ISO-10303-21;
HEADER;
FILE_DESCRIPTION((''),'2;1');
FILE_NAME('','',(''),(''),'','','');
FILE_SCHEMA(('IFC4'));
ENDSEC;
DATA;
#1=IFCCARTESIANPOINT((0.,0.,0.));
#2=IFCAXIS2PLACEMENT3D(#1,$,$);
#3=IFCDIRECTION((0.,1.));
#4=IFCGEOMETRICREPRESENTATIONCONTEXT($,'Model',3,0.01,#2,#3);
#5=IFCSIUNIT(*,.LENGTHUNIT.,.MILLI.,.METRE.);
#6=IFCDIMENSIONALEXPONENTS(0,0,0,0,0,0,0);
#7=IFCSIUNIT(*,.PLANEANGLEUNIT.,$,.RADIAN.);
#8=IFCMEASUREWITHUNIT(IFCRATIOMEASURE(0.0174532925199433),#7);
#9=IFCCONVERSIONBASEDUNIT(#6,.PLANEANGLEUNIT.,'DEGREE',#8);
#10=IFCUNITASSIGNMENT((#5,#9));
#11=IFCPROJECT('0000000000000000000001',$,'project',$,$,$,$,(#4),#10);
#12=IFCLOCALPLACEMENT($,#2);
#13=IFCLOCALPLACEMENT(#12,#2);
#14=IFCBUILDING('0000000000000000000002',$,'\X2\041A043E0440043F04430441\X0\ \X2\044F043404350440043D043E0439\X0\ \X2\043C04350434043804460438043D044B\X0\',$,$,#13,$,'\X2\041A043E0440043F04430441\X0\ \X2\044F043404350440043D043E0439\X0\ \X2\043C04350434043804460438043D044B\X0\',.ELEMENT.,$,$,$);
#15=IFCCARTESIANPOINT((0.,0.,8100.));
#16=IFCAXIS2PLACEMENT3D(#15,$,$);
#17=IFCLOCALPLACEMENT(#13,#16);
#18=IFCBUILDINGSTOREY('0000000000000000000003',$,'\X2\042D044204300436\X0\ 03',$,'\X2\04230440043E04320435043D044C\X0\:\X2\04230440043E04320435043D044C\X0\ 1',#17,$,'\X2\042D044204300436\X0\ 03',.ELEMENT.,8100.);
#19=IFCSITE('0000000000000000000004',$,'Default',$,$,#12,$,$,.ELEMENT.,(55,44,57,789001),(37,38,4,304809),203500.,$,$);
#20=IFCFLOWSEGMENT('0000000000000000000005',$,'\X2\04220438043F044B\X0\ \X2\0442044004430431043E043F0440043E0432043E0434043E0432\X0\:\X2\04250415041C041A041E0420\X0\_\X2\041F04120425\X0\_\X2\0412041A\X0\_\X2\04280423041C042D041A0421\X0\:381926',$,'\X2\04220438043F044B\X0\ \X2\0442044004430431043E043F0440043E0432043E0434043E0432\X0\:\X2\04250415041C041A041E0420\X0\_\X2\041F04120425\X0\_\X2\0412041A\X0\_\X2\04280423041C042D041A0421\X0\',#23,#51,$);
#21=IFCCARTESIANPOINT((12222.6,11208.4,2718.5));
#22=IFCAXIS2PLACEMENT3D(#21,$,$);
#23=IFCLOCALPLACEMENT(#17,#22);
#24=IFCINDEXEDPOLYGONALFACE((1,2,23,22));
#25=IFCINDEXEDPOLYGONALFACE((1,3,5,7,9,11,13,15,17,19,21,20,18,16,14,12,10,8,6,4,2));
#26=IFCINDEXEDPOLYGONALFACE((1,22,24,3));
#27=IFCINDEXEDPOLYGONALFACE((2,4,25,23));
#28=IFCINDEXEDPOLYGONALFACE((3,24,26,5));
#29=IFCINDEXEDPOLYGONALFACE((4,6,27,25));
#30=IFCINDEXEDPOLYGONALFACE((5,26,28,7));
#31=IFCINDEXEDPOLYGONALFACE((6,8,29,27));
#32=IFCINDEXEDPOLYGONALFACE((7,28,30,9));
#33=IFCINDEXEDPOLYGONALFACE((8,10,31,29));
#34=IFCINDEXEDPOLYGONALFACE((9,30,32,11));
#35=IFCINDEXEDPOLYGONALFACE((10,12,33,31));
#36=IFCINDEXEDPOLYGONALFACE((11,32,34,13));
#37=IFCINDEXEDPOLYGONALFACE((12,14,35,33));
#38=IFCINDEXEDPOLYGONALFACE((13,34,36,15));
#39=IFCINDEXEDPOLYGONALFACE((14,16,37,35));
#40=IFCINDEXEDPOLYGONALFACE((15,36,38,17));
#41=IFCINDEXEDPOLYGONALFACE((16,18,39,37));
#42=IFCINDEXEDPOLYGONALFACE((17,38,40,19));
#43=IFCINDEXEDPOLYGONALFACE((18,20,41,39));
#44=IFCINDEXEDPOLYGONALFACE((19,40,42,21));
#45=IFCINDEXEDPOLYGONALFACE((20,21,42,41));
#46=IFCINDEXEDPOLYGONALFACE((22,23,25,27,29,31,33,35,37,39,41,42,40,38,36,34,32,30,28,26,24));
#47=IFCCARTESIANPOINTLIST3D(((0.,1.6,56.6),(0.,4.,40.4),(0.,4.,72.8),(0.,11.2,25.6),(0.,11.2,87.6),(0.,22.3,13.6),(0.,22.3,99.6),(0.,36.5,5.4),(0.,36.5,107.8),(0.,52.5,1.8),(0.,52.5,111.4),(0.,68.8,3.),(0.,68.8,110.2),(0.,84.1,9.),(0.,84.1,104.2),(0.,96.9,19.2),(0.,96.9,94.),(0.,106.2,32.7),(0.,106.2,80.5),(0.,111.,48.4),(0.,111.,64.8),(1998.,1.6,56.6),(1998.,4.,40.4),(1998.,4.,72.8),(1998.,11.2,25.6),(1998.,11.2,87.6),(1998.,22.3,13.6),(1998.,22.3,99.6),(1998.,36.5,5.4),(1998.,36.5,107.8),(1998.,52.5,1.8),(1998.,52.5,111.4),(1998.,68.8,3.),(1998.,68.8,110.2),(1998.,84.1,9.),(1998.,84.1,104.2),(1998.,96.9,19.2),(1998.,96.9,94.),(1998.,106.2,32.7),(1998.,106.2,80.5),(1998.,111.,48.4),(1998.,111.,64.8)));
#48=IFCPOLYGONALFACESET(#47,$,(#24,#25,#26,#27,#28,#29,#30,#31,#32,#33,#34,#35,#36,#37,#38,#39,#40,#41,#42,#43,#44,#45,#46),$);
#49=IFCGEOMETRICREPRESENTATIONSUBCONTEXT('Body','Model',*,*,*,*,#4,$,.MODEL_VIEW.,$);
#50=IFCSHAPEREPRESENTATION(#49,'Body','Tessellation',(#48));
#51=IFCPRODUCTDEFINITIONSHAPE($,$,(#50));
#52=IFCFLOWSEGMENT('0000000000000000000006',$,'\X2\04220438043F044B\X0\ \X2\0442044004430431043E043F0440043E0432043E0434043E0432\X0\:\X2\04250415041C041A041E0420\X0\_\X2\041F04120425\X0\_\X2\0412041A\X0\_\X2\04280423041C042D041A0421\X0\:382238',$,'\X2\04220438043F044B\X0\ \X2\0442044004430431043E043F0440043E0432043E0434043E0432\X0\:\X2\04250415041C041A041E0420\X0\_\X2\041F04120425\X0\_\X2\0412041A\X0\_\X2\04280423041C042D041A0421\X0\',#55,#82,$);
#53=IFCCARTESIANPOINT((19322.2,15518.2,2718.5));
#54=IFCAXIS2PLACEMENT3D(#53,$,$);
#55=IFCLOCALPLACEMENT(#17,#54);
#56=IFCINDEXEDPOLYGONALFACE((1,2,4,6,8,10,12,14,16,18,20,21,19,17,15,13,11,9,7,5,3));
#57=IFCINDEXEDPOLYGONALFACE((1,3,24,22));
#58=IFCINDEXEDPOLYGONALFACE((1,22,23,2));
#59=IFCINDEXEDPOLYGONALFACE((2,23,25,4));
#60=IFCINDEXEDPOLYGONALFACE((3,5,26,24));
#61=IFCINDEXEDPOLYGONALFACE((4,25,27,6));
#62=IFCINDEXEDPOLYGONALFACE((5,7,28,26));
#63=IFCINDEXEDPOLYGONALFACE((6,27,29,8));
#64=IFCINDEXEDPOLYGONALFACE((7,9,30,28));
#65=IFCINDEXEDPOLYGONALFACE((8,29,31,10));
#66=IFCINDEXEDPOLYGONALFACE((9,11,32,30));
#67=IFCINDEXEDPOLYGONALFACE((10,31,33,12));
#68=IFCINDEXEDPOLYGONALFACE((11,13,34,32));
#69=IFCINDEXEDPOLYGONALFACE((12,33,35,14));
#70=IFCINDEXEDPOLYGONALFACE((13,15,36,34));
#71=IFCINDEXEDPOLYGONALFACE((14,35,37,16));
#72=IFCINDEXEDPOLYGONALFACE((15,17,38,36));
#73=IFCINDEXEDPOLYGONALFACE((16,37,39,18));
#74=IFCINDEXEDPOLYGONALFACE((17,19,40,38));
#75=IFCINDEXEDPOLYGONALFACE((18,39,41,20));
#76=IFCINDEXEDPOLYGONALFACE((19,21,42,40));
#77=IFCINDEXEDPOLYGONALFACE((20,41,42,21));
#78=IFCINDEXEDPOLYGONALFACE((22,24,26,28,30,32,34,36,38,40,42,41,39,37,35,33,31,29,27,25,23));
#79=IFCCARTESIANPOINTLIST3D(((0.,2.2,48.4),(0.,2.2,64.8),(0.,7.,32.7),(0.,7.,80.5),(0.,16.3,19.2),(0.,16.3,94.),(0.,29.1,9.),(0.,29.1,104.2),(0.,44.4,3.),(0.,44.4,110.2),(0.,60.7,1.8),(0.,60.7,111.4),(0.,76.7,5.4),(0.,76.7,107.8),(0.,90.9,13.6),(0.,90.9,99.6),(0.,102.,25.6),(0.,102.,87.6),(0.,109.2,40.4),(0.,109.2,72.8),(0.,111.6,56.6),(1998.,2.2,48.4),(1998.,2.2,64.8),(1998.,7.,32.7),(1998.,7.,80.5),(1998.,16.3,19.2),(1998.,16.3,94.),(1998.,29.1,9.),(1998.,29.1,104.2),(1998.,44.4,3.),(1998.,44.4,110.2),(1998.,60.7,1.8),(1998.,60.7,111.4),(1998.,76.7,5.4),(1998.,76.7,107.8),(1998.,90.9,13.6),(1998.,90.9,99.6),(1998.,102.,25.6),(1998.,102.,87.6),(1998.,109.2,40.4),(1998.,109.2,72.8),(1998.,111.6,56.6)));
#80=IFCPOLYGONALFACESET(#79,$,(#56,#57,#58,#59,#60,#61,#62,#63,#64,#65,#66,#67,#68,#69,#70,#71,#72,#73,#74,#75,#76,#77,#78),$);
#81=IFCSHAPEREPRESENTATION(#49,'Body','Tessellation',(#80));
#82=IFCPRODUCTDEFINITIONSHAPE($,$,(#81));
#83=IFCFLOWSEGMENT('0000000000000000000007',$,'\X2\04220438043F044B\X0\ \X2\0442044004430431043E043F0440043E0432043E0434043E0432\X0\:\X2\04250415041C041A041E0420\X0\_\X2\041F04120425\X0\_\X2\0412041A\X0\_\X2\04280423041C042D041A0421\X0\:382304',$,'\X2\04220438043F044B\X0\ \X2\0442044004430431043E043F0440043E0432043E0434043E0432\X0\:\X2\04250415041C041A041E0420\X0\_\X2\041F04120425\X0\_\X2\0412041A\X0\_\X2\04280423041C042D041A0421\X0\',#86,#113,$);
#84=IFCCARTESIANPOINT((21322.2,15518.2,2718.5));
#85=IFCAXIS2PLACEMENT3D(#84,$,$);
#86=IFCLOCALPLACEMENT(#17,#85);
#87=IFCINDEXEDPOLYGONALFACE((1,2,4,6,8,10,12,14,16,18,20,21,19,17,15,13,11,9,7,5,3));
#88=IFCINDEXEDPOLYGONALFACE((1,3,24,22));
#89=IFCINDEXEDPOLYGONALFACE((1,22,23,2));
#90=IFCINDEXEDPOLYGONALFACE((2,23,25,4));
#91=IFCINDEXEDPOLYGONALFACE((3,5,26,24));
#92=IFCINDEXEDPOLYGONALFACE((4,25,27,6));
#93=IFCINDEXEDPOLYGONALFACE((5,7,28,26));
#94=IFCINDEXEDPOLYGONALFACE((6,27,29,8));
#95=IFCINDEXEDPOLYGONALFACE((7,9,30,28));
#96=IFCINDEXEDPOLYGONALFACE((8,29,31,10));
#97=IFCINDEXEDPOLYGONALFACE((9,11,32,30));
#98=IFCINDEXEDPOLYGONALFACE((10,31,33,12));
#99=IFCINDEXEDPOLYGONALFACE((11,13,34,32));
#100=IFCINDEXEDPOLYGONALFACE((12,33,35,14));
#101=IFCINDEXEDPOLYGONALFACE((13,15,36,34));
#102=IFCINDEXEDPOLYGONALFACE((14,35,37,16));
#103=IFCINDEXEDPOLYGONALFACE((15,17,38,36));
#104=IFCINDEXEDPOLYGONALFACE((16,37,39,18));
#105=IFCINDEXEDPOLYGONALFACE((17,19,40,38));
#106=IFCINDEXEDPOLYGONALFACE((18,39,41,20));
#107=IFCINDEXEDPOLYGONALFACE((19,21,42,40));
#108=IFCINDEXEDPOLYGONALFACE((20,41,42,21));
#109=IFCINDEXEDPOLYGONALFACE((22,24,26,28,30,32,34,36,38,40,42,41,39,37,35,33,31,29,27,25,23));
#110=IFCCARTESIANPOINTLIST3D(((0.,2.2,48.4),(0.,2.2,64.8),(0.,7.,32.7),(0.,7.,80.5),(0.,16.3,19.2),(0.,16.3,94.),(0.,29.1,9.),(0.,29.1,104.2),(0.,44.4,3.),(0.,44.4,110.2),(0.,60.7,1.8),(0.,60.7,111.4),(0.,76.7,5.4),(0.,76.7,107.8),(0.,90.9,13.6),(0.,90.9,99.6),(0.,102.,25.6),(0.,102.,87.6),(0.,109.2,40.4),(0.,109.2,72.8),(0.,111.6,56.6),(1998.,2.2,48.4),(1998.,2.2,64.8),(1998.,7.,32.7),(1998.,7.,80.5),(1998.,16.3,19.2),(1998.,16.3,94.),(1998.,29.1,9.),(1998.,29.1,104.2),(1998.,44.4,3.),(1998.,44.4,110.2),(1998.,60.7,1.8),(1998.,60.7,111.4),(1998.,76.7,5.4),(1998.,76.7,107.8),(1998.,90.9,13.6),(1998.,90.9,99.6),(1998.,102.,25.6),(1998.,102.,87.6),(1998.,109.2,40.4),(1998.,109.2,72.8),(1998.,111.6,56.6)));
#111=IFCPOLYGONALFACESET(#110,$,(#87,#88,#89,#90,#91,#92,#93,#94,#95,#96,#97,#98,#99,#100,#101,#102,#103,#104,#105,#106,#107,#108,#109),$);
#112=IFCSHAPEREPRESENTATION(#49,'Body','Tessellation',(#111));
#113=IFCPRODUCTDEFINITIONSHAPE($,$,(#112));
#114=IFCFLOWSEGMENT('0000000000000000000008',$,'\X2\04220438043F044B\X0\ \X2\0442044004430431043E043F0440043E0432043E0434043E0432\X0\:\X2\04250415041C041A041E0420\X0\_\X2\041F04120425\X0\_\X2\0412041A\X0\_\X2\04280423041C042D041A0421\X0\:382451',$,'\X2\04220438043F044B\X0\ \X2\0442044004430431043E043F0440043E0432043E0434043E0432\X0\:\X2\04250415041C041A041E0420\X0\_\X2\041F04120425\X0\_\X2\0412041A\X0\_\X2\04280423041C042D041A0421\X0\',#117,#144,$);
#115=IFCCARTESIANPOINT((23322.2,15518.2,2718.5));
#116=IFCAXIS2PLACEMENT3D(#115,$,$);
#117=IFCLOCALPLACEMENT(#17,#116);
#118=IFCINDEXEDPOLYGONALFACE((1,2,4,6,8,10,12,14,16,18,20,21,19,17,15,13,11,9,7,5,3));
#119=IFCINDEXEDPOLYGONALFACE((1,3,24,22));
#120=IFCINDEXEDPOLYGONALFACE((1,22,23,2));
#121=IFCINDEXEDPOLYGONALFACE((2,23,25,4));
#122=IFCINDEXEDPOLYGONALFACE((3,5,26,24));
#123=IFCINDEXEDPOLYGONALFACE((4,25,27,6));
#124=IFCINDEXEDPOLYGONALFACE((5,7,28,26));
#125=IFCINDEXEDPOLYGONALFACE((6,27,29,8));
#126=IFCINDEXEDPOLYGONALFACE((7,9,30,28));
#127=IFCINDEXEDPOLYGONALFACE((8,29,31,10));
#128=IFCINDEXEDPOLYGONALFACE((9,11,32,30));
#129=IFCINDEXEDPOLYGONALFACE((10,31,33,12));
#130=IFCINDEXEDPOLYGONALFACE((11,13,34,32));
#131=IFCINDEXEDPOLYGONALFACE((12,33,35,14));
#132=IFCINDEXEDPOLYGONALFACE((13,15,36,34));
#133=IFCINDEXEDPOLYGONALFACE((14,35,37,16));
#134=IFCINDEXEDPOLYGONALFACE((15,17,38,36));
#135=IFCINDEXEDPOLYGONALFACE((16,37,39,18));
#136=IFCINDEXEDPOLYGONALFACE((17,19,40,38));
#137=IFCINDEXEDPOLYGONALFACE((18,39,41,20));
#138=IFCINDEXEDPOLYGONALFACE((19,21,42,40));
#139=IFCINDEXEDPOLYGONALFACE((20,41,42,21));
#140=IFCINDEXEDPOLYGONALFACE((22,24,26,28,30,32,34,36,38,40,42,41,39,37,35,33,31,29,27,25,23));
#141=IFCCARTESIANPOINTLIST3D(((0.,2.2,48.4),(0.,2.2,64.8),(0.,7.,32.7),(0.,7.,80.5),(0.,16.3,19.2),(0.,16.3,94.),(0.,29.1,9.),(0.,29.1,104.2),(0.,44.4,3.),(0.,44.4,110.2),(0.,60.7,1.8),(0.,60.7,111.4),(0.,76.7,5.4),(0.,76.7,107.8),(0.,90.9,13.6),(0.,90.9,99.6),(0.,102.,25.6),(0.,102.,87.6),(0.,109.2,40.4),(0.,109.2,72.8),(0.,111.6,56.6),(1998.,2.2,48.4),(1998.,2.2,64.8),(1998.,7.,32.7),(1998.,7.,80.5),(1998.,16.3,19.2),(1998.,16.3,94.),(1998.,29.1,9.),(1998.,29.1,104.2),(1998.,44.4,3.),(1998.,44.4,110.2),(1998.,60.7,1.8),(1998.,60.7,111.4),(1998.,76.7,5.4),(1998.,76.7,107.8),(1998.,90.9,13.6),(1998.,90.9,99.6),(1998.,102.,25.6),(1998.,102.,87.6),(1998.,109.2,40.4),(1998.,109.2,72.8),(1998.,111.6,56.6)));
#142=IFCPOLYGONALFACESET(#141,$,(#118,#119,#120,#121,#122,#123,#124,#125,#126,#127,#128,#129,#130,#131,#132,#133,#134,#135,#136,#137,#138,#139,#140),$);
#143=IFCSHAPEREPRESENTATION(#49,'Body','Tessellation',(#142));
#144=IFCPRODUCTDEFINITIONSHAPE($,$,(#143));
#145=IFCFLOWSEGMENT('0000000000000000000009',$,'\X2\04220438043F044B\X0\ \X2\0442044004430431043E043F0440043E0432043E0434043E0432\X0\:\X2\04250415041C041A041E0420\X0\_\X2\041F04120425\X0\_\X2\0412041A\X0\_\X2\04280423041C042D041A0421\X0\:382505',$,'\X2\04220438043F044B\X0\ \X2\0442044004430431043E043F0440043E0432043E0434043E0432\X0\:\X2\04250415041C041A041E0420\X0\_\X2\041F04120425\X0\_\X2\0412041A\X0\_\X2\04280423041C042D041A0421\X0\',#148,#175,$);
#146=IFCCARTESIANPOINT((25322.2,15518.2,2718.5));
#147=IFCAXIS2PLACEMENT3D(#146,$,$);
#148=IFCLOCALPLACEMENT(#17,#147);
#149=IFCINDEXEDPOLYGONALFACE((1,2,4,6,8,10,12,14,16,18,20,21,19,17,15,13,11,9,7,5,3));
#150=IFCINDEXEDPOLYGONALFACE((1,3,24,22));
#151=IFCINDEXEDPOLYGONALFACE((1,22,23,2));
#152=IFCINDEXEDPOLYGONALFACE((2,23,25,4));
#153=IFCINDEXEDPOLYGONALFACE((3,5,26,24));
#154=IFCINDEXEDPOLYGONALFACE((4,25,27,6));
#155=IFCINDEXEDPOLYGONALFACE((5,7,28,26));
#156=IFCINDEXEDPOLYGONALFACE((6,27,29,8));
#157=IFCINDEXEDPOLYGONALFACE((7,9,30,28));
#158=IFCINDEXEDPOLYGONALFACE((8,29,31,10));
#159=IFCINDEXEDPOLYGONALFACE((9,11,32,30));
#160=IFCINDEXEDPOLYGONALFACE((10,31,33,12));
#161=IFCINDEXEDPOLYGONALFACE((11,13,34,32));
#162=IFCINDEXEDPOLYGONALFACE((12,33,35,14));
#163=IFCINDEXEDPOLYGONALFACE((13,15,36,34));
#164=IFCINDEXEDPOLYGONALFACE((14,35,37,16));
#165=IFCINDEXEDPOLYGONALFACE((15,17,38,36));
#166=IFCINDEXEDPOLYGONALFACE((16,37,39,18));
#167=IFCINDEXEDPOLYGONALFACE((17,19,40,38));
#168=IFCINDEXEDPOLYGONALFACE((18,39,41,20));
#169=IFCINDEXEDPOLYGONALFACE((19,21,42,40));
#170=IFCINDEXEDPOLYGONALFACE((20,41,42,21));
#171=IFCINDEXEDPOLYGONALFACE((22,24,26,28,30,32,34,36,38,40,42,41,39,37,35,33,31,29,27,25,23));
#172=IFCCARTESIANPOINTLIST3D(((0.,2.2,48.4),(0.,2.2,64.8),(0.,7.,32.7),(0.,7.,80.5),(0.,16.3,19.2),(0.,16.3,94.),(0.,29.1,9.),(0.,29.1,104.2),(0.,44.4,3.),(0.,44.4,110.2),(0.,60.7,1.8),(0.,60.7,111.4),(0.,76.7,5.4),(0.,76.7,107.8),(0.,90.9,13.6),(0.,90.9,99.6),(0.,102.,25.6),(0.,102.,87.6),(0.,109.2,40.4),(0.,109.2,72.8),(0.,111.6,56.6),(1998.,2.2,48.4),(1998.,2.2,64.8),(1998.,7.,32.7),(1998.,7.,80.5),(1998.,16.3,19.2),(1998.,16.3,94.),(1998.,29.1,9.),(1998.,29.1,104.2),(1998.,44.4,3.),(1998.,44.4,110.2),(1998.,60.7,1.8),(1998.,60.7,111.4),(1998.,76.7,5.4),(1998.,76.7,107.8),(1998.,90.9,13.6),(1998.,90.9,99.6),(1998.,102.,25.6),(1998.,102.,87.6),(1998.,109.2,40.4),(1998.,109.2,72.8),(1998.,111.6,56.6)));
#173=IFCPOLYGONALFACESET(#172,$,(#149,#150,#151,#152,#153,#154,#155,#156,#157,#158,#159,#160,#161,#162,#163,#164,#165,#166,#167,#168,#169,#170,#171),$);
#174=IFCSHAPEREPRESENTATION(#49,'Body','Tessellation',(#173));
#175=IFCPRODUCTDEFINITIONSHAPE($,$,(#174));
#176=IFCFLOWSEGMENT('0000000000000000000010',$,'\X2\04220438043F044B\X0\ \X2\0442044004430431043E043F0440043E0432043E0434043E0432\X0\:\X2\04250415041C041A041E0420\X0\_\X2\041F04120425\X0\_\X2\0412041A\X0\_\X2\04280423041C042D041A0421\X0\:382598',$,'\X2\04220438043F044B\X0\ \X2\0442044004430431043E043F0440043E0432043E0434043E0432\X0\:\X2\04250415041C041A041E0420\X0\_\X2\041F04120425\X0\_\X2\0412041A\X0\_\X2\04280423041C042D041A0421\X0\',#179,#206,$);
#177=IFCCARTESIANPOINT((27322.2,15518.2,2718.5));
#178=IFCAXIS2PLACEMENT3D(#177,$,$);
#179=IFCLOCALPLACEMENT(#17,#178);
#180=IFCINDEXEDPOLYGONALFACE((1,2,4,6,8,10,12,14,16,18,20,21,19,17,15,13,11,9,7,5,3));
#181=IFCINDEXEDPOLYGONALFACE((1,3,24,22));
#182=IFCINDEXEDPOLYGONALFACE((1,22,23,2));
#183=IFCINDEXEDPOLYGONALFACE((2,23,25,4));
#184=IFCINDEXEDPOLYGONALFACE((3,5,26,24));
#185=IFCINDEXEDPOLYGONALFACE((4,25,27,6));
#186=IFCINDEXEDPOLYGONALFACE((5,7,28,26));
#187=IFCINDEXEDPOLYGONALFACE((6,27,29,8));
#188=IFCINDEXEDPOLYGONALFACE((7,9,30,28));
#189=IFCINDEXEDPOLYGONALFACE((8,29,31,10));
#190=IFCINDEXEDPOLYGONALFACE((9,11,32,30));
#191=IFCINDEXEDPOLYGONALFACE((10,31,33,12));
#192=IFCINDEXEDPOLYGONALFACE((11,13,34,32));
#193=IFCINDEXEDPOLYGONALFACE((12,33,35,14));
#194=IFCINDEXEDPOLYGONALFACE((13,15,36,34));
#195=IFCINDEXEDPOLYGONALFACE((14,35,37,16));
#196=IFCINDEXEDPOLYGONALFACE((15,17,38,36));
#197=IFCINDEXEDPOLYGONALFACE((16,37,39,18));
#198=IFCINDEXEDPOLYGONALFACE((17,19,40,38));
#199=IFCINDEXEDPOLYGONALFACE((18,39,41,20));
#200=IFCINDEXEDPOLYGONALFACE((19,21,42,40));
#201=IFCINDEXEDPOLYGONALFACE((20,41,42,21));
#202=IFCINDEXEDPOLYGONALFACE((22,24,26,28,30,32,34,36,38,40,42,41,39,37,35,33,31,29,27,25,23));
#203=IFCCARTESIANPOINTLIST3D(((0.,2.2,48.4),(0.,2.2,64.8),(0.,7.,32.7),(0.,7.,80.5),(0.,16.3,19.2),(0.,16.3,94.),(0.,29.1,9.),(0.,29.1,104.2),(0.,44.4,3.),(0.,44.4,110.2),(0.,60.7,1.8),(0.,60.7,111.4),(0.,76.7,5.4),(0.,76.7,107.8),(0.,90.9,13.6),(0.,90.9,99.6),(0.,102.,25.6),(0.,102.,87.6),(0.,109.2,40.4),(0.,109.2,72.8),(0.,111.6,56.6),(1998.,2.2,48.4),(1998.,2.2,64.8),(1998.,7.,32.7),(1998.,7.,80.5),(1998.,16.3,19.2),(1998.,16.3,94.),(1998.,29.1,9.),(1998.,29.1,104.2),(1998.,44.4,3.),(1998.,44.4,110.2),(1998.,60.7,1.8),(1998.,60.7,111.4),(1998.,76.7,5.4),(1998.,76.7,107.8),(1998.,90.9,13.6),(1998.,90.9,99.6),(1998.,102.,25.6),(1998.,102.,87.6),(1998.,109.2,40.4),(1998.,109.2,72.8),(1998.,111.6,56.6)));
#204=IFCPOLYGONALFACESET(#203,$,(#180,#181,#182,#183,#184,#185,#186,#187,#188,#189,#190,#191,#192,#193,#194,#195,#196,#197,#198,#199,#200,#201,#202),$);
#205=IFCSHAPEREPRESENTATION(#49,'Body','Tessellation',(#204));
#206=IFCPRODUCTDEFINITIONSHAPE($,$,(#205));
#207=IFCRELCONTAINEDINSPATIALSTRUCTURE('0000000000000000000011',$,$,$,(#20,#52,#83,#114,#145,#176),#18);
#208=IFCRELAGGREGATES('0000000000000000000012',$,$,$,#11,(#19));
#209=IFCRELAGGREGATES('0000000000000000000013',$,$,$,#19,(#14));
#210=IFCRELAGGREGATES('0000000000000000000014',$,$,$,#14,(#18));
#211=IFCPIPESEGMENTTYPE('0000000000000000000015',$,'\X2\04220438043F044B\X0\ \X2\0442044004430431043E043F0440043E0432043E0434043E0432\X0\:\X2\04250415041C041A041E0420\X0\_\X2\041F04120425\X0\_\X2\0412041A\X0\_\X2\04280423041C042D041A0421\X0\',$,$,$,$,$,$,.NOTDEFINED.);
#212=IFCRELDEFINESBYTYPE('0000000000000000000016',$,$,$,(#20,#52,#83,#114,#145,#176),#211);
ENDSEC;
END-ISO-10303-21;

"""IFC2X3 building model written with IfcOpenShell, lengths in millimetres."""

from ifc_helpers import new_model, entity, si_unit, converted_unit, direction, frame, origin, origin_2d_with_axis, place, context, subcontext, project, spatial, circle, extrude, type_object, element, save


model = new_model("IFC2X3")

# Units and contexts
model_context = context("Model", 3, precision=0.01, world=origin(), true_north=direction((0.0, 1.0)))
body_context = subcontext(model_context, "Body", "Model", "MODEL_VIEW")
ifc_project = project(units=[si_unit("LENGTHUNIT", "METRE", prefix="MILLI"), converted_unit("PLANEANGLEUNIT", "DEGREE", entity("IfcRatioMeasure", 0.0174532925199433), si_unit("PLANEANGLEUNIT", "RADIAN"), dimensions=[0, 0, 0, 0, 0, 0, 0])], contexts=[model_context])

# Site, building, storey
site_placement = place(None, origin())
site = spatial("IfcSite", under=ifc_project, at=site_placement, Name="Default", CompositionType="ELEMENT", RefLatitude=(55, 44, 57, 789001), RefLongitude=(37, 38, 4, 304809), RefElevation=203500.0)
building_placement = place(site_placement, origin())
building = spatial("IfcBuilding", under=site, at=building_placement, Name="Корпус ядерной медицины", LongName="Корпус ядерной медицины", CompositionType="ELEMENT")
storey_placement = place(building_placement, frame((0.0, 0.0, 8100.0)))
storey = spatial("IfcBuildingStorey", under=building, at=storey_placement, Name="Этаж 03", ObjectType="Уровень:Уровень 1", LongName="Этаж 03", CompositionType="ELEMENT", Elevation=8100.0)

# Flow segments
pipe_segment_type = type_object("IfcPipeSegmentType", Name="Типы трубопроводов:ХЕМКОР_ПВХ_ВК_ШУМЭКС", PredefinedType="NOTDEFINED")
for number, where, name in (
    (1, (12222.6, 11208.4, 2718.5), "Типы трубопроводов:ХЕМКОР_ПВХ_ВК_ШУМЭКС:381926"),
):
    element("IfcFlowSegment", number, at=place(storey_placement, frame(where)), inside=storey, type_object=pipe_segment_type, Name=name, ObjectType="Типы трубопроводов:ХЕМКОР_ПВХ_ВК_ШУМЭКС", context=body_context, shape_type="SweptSolid", body=[
        extrude(circle(Radius=55.0, at=origin_2d_with_axis()), frame((0.0, 56.6, 56.6), z_axis=(1.0, 0.0, 0.0), x_axis=(0.0, -1.0, 0.0)), (0.0, 0.0, 1.0), 1998.0),
    ])
for number, where, name in (
    (2, (19322.2, 15518.2, 2718.5), "Типы трубопроводов:ХЕМКОР_ПВХ_ВК_ШУМЭКС:382238"),
    (3, (21322.2, 15518.2, 2718.5), "Типы трубопроводов:ХЕМКОР_ПВХ_ВК_ШУМЭКС:382304"),
    (4, (23322.2, 15518.2, 2718.5), "Типы трубопроводов:ХЕМКОР_ПВХ_ВК_ШУМЭКС:382451"),
    (5, (25322.2, 15518.2, 2718.5), "Типы трубопроводов:ХЕМКОР_ПВХ_ВК_ШУМЭКС:382505"),
    (6, (27322.2, 15518.2, 2718.5), "Типы трубопроводов:ХЕМКОР_ПВХ_ВК_ШУМЭКС:382598"),
):
    element("IfcFlowSegment", number, at=place(storey_placement, frame(where)), inside=storey, type_object=pipe_segment_type, Name=name, ObjectType="Типы трубопроводов:ХЕМКОР_ПВХ_ВК_ШУМЭКС", context=body_context, shape_type="SweptSolid", body=[
        extrude(circle(Radius=55.0, at=origin_2d_with_axis()), frame((0.0, 56.6, 56.6), z_axis=(1.0, 0.0, 0.0), x_axis=(0.0, 1.0, 0.0)), (0.0, 0.0, 1.0), 1998.0),
    ])

save(model, "model.ifc")
